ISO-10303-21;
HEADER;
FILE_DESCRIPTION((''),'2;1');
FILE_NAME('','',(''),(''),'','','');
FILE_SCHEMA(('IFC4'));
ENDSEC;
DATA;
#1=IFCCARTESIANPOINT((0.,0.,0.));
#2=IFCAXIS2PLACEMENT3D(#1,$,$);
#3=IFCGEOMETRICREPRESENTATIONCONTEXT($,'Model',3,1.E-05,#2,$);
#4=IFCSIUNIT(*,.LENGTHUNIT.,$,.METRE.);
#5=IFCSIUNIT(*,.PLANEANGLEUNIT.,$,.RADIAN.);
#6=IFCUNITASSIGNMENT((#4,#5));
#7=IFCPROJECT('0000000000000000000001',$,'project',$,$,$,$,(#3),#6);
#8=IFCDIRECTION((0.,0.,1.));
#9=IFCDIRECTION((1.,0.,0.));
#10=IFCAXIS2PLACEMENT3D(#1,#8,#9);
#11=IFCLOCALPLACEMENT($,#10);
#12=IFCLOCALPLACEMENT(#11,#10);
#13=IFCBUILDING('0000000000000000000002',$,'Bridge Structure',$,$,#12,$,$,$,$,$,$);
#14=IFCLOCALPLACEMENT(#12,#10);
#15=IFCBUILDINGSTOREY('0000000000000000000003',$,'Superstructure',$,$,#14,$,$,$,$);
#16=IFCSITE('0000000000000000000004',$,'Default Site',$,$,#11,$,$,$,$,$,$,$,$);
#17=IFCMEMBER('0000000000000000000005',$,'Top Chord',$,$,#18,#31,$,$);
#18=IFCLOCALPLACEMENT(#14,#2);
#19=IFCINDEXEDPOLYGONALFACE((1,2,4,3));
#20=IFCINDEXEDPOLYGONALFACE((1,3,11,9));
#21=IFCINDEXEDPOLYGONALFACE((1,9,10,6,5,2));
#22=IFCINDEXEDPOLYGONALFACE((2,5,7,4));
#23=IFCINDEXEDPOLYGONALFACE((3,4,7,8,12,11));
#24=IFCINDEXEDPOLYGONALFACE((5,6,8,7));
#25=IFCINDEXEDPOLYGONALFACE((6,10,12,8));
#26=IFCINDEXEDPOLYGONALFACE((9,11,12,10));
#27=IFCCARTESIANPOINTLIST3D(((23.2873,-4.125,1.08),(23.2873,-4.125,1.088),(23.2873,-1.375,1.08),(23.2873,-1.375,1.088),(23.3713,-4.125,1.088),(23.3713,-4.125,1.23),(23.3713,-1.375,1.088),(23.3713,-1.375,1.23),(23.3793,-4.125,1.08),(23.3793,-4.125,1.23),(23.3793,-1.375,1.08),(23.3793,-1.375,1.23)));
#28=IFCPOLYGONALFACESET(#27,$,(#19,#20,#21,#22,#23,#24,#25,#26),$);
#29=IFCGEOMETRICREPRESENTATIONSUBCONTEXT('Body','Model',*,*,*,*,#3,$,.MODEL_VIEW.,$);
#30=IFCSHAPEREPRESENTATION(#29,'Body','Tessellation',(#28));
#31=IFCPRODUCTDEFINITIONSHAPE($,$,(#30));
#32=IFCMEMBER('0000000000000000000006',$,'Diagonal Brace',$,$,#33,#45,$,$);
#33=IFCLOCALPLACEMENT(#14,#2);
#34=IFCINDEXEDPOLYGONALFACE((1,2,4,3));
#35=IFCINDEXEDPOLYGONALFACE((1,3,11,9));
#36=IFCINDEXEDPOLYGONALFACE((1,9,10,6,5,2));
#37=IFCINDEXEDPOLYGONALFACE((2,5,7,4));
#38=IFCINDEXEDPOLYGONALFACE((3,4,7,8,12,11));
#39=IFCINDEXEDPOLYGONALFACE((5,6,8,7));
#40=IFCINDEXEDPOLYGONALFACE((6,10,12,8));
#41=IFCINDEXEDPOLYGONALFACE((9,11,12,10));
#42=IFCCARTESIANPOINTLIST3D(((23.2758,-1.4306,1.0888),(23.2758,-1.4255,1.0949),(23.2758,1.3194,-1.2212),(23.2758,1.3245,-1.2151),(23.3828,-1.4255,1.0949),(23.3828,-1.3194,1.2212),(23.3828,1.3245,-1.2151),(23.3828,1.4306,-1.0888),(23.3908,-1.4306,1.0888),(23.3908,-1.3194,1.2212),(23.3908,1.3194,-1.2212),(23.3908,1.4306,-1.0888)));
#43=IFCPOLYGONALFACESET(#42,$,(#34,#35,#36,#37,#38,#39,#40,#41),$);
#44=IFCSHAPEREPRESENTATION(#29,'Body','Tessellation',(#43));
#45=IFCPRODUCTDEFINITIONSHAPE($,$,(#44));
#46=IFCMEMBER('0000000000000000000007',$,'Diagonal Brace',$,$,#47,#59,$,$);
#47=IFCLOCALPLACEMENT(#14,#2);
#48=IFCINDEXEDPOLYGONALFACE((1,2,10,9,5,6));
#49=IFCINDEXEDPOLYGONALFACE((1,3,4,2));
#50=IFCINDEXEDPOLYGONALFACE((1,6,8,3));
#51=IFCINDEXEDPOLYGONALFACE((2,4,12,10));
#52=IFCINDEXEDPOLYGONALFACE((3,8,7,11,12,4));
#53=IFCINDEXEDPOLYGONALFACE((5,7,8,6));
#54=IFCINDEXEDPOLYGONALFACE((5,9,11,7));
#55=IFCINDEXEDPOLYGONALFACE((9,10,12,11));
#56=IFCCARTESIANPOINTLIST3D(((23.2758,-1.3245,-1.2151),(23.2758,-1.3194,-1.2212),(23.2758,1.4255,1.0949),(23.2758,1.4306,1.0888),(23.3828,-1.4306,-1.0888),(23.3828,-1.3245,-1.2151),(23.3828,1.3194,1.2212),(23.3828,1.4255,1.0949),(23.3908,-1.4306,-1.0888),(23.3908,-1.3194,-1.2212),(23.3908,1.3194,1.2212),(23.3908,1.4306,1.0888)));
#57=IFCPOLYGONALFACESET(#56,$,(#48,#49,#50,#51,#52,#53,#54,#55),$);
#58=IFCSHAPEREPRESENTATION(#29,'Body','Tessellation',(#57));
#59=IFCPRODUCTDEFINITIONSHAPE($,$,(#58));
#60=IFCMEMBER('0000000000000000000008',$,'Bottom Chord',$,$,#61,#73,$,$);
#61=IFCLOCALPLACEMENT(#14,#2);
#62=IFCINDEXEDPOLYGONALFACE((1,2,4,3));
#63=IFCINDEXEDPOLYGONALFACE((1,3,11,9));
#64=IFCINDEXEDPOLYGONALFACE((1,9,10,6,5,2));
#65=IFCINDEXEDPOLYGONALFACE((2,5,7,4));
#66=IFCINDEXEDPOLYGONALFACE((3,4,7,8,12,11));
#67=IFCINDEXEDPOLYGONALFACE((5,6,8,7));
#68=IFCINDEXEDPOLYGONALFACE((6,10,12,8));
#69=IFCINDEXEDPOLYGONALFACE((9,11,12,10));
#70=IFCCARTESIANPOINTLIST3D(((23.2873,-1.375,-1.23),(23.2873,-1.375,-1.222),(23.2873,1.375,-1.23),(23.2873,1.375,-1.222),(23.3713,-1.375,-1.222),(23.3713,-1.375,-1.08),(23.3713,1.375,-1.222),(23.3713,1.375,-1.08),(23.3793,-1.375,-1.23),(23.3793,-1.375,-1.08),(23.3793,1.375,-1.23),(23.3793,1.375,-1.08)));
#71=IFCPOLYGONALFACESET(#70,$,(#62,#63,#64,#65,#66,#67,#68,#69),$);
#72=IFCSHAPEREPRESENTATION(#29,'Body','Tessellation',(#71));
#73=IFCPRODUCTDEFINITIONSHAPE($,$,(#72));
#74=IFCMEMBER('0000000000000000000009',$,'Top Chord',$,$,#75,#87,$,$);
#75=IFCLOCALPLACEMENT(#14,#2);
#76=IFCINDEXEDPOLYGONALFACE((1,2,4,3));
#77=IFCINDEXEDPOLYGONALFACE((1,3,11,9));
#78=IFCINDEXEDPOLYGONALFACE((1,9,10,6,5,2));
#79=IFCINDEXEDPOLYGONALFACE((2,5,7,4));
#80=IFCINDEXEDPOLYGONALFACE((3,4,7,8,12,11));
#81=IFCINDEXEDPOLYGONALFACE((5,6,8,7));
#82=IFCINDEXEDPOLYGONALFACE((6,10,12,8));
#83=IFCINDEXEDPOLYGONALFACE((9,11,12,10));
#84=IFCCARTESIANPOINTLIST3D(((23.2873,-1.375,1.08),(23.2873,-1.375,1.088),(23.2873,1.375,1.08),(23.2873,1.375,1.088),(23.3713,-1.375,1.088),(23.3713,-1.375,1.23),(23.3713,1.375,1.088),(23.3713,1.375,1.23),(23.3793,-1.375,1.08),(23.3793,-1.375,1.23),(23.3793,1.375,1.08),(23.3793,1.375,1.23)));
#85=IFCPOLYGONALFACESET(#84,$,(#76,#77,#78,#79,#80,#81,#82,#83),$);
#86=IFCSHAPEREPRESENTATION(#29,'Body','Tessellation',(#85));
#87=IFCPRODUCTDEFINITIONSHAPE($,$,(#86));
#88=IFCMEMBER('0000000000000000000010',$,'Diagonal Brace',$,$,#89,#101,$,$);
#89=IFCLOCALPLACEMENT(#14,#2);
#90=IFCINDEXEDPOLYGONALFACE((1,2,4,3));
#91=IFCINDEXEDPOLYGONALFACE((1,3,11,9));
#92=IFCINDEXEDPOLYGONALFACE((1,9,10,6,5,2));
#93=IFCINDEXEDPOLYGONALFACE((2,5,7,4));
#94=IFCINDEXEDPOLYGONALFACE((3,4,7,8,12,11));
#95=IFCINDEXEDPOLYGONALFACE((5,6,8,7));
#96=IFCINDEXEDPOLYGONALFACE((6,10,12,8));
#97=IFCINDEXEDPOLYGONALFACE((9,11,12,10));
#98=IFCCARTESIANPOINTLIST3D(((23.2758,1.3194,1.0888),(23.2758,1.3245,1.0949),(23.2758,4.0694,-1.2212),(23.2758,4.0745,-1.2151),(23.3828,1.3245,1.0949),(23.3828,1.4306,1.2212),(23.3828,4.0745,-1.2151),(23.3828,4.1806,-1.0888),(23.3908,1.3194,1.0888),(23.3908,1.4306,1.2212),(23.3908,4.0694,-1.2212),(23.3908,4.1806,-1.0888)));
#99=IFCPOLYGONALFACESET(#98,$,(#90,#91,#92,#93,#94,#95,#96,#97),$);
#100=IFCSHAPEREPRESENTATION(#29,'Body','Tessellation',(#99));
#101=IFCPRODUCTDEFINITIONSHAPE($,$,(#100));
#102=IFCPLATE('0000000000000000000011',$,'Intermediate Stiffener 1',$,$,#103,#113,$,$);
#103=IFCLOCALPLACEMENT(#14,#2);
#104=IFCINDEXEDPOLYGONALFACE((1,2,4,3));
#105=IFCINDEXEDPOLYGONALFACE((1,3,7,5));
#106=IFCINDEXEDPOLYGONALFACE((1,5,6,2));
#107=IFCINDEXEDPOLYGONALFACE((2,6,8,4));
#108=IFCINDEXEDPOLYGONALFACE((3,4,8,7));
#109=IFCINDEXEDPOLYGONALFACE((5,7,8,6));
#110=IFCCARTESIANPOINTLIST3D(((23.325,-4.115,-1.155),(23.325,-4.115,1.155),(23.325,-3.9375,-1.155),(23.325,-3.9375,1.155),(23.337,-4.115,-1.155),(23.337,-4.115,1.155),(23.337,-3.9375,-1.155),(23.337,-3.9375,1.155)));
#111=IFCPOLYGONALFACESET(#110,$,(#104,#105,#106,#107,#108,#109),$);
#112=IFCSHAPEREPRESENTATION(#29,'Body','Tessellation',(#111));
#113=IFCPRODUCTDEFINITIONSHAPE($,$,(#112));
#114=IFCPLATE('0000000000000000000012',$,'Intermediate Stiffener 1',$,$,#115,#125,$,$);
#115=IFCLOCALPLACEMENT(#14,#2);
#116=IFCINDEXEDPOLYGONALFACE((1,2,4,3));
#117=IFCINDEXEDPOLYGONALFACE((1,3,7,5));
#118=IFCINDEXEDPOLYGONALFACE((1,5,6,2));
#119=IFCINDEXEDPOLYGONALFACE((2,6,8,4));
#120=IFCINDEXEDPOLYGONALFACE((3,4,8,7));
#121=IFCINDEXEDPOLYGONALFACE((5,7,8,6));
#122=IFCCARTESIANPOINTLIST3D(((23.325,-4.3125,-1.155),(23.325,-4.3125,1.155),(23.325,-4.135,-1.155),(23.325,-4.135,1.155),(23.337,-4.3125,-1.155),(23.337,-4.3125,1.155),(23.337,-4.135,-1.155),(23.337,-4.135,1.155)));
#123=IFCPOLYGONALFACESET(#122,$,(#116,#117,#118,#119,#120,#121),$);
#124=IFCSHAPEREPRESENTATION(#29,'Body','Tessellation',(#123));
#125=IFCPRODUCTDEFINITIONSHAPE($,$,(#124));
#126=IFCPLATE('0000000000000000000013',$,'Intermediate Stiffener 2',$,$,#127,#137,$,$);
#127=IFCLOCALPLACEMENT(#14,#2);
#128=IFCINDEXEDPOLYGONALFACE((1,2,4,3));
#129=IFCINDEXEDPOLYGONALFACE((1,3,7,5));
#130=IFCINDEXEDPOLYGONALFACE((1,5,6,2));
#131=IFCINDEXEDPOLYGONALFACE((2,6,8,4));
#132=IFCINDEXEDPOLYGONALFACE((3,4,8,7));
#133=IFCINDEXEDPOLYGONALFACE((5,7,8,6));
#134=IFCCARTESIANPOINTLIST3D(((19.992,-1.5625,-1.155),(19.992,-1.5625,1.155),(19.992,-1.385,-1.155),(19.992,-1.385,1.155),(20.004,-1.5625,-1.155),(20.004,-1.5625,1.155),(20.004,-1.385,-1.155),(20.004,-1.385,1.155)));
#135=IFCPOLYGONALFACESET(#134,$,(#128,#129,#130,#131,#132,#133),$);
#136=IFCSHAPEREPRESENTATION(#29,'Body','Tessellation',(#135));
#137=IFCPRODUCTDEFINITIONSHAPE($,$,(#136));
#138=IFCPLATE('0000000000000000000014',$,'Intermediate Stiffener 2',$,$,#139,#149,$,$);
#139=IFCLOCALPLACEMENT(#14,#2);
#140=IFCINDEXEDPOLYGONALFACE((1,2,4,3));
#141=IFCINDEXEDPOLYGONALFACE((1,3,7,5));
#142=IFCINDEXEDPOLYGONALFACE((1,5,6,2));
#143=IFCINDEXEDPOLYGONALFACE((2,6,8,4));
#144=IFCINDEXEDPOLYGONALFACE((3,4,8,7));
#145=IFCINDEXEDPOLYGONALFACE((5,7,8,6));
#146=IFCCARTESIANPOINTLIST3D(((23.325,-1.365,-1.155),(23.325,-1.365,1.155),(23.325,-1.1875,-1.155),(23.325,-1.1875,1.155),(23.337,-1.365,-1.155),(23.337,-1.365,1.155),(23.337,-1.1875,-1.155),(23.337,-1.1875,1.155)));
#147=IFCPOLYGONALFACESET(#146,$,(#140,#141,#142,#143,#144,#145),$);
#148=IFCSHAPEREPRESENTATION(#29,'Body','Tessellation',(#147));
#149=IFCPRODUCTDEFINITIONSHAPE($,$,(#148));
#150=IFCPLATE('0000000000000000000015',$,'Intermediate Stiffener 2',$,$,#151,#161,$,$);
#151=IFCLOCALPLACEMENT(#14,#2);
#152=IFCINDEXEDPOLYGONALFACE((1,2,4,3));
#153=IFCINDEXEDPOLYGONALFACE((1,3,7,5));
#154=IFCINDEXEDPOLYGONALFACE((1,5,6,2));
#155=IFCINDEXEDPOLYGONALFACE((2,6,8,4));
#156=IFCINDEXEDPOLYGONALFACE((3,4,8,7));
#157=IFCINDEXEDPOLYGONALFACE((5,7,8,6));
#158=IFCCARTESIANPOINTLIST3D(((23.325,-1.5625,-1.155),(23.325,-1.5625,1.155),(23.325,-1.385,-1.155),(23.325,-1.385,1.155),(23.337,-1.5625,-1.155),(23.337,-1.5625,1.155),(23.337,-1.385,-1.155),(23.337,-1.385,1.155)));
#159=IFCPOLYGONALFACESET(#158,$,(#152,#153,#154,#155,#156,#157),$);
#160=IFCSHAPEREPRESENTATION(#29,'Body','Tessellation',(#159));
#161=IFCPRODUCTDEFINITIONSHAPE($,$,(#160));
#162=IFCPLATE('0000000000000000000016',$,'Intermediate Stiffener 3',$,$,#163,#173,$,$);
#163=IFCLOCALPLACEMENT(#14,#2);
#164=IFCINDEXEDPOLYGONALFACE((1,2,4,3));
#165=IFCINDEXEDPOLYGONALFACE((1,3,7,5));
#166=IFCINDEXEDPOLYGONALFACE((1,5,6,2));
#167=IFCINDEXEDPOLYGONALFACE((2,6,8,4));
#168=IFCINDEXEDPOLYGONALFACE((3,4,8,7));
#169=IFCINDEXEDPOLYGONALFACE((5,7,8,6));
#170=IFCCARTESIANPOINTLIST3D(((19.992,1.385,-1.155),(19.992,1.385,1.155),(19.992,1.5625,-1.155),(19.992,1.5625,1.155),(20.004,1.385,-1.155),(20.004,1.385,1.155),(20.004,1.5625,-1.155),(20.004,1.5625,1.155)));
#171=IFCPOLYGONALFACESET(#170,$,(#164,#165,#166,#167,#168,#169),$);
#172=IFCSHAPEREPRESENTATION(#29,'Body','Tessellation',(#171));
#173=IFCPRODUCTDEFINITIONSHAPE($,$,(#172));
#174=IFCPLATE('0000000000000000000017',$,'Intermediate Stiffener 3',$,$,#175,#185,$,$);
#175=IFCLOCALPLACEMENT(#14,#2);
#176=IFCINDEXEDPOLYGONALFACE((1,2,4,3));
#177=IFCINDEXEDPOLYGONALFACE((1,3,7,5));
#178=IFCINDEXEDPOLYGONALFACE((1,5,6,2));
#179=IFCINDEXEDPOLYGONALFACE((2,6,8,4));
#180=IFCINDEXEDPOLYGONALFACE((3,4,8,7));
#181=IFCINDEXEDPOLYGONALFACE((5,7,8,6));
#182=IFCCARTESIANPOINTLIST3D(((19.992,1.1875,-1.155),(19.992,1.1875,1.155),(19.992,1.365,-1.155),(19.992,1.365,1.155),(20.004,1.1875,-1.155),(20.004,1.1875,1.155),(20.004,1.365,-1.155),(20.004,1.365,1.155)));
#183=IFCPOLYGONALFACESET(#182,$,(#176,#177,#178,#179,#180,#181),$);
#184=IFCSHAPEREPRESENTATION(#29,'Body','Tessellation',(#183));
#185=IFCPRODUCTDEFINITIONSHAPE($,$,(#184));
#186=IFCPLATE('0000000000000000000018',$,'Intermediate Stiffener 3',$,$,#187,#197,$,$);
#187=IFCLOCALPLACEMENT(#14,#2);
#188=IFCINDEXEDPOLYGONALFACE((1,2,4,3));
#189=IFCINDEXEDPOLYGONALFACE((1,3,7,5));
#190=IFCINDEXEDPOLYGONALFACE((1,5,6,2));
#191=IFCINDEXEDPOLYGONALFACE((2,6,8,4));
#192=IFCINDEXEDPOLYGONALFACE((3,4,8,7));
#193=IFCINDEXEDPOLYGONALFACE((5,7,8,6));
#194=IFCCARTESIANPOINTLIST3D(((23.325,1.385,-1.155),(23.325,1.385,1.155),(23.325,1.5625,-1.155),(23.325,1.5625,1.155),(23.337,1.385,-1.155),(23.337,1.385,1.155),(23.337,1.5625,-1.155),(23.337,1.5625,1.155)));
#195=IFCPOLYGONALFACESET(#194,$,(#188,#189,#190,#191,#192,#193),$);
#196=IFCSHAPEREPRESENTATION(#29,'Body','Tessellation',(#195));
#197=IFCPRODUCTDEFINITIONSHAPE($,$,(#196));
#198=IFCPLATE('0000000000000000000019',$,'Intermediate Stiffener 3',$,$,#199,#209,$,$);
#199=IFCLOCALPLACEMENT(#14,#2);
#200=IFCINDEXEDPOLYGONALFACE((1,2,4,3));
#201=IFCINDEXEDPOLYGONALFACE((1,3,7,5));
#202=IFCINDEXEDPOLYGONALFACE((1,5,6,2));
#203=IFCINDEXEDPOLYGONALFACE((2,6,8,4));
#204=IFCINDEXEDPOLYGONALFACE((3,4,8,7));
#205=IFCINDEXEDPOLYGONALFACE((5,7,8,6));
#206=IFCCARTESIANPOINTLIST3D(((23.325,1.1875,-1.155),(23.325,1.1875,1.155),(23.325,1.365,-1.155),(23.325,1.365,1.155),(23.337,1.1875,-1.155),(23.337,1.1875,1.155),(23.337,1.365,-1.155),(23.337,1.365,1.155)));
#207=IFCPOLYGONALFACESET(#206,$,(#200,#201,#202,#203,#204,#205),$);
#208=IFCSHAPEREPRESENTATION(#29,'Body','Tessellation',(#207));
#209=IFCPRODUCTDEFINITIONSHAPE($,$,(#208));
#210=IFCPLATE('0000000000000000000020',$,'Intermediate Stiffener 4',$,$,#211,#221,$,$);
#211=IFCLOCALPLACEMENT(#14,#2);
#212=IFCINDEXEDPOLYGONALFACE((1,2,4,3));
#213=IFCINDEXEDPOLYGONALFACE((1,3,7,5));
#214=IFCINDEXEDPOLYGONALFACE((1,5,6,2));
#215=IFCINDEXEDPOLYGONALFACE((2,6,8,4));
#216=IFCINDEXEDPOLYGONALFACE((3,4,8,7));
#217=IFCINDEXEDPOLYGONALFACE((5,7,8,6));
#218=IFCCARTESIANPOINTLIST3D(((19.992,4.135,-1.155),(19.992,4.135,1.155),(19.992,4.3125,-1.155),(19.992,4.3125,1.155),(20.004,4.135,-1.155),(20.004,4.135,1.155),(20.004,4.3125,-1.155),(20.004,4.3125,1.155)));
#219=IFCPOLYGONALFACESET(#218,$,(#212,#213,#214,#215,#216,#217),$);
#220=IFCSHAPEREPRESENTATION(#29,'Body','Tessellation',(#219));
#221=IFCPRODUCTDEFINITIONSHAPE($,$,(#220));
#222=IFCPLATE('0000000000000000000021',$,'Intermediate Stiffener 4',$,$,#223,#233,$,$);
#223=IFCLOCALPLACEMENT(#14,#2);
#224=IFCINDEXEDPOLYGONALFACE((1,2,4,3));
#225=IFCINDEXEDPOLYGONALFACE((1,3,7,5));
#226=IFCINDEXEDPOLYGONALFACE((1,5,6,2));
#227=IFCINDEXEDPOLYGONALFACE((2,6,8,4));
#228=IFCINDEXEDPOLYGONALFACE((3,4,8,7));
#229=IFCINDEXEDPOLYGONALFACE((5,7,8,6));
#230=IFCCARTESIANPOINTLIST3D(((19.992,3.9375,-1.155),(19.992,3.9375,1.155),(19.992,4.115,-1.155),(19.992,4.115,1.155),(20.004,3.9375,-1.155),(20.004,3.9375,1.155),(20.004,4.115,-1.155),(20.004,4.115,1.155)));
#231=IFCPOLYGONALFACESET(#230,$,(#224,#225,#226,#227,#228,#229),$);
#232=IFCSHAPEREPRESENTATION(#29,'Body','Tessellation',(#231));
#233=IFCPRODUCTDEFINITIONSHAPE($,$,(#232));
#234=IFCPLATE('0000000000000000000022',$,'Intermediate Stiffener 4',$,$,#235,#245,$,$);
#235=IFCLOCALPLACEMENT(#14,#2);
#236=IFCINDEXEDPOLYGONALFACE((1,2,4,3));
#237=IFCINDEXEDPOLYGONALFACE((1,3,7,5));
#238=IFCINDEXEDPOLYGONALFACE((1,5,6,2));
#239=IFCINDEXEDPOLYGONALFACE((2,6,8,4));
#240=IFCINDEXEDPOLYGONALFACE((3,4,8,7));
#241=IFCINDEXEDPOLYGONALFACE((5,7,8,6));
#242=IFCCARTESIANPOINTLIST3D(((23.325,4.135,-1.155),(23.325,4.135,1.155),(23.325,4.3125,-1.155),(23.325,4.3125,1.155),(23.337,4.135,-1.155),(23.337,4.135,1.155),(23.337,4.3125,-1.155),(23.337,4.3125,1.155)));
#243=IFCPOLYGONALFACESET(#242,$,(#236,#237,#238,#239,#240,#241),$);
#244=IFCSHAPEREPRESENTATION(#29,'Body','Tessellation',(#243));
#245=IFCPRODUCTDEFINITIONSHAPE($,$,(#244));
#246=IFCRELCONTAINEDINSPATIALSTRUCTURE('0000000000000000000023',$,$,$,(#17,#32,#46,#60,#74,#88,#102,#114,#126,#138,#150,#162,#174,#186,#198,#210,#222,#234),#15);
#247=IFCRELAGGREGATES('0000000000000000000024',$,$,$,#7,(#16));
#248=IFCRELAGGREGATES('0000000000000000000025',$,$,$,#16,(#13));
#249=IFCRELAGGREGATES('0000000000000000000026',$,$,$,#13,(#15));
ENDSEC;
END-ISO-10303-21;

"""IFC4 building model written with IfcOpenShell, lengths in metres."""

from ifc_helpers import new_model, si_unit, frame, origin, origin_with_axes, origin_2d_with_axis, place, context, subcontext, project, spatial, rectangle, l_section, extrude, element, save


model = new_model("IFC4")

# Units and contexts
model_context = context("Model", 3, precision=1e-05, world=origin())
body_context = subcontext(model_context, "Body", "Model", "MODEL_VIEW")
ifc_project = project(units=[si_unit("LENGTHUNIT", "METRE"), si_unit("PLANEANGLEUNIT", "RADIAN")], contexts=[model_context])

# Site, building, storey
site_placement = place(None, origin_with_axes())
site = spatial("IfcSite", under=ifc_project, at=site_placement, Name="Default Site")
building_placement = place(site_placement, origin_with_axes())
building = spatial("IfcBuilding", under=site, at=building_placement, Name="Bridge Structure")
storey_placement = place(building_placement, origin_with_axes())
storey = spatial("IfcBuildingStorey", under=building, at=storey_placement, Name="Superstructure")

# Members
for number, where, z_axis, x_axis, name in (
    (1, (23.3333, -4.125, 1.155), (0.0, 1.0, 0.0), (-1.0, 0.0, 0.0), "Top Chord"),
):
    element("IfcMember", number, at=place(storey_placement, frame(where, z_axis=z_axis, x_axis=x_axis)), inside=storey, Name=name, context=body_context, shape_type="SweptSolid", body=[
        extrude(l_section(Depth=0.15, Width=0.092, Thickness=0.008, at=origin_2d_with_axis()), origin_with_axes(), (0.0, 0.0, 1.0), 2.75),
    ])
for number, where, z_axis, x_axis, name in (
    (2, (23.3333, -1.375, 1.155), (0.0, 0.765705, -0.643192), (-1.0, 0.0, 0.0), "Diagonal Brace"),
    (3, (23.3333, -1.375, -1.155), (0.0, 0.765705, 0.643192), (-1.0, 0.0, 0.0), "Diagonal Brace"),
):
    element("IfcMember", number, at=place(storey_placement, frame(where, z_axis=z_axis, x_axis=x_axis)), inside=storey, Name=name, context=body_context, shape_type="SweptSolid", body=[
        extrude(l_section(Depth=0.173, Width=0.115, Thickness=0.008, at=origin_2d_with_axis()), origin_with_axes(), (0.0, 0.0, 1.0), 3.5915),
    ])
for number, where, z_axis, x_axis, name in (
    (4, (23.3333, -1.375, -1.155), (0.0, 1.0, 0.0), (-1.0, 0.0, 0.0), "Bottom Chord"),
    (5, (23.3333, -1.375, 1.155), (0.0, 1.0, 0.0), (-1.0, 0.0, 0.0), "Top Chord"),
):
    element("IfcMember", number, at=place(storey_placement, frame(where, z_axis=z_axis, x_axis=x_axis)), inside=storey, Name=name, context=body_context, shape_type="SweptSolid", body=[
        extrude(l_section(Depth=0.15, Width=0.092, Thickness=0.008, at=origin_2d_with_axis()), origin_with_axes(), (0.0, 0.0, 1.0), 2.75),
    ])
member_placement = place(storey_placement, frame((23.3333, 1.375, 1.155), z_axis=(0.0, 0.765705, -0.643192), x_axis=(-1.0, 0.0, 0.0)))
element("IfcMember", 6, at=member_placement, inside=storey, Name="Diagonal Brace", context=body_context, shape_type="SweptSolid", body=[
    extrude(l_section(Depth=0.173, Width=0.115, Thickness=0.008, at=origin_2d_with_axis()), origin_with_axes(), (0.0, 0.0, 1.0), 3.5915),
])

# Plates
for number, where, z_axis, x_axis, name in (
    (7, (23.331, -4.0263, -1.155), (0.0, 0.0, 1.0), (1.0, 0.0, 0.0), "Intermediate Stiffener 1"),
    (8, (23.331, -4.2237, -1.155), (0.0, 0.0, 1.0), (1.0, 0.0, 0.0), "Intermediate Stiffener 1"),
    (9, (19.998, -1.4738, -1.155), (0.0, 0.0, 1.0), (1.0, 0.0, 0.0), "Intermediate Stiffener 2"),
    (10, (23.331, -1.2763, -1.155), (0.0, 0.0, 1.0), (1.0, 0.0, 0.0), "Intermediate Stiffener 2"),
    (11, (23.331, -1.4738, -1.155), (0.0, 0.0, 1.0), (1.0, 0.0, 0.0), "Intermediate Stiffener 2"),
    (12, (19.998, 1.4738, -1.155), (0.0, 0.0, 1.0), (1.0, 0.0, 0.0), "Intermediate Stiffener 3"),
    (13, (19.998, 1.2763, -1.155), (0.0, 0.0, 1.0), (1.0, 0.0, 0.0), "Intermediate Stiffener 3"),
    (14, (23.331, 1.4738, -1.155), (0.0, 0.0, 1.0), (1.0, 0.0, 0.0), "Intermediate Stiffener 3"),
    (15, (23.331, 1.2763, -1.155), (0.0, 0.0, 1.0), (1.0, 0.0, 0.0), "Intermediate Stiffener 3"),
    (16, (19.998, 4.2237, -1.155), (0.0, 0.0, 1.0), (1.0, 0.0, 0.0), "Intermediate Stiffener 4"),
    (17, (19.998, 4.0263, -1.155), (0.0, 0.0, 1.0), (1.0, 0.0, 0.0), "Intermediate Stiffener 4"),
    (18, (23.331, 4.2237, -1.155), (0.0, 0.0, 1.0), (1.0, 0.0, 0.0), "Intermediate Stiffener 4"),
):
    element("IfcPlate", number, at=place(storey_placement, frame(where, z_axis=z_axis, x_axis=x_axis)), inside=storey, Name=name, context=body_context, shape_type="SweptSolid", body=[
        extrude(rectangle(XDim=0.012, YDim=0.1775, at=origin_2d_with_axis()), origin_with_axes(), (0.0, 0.0, 1.0), 2.31),
    ])

save(model, "model.ifc")
